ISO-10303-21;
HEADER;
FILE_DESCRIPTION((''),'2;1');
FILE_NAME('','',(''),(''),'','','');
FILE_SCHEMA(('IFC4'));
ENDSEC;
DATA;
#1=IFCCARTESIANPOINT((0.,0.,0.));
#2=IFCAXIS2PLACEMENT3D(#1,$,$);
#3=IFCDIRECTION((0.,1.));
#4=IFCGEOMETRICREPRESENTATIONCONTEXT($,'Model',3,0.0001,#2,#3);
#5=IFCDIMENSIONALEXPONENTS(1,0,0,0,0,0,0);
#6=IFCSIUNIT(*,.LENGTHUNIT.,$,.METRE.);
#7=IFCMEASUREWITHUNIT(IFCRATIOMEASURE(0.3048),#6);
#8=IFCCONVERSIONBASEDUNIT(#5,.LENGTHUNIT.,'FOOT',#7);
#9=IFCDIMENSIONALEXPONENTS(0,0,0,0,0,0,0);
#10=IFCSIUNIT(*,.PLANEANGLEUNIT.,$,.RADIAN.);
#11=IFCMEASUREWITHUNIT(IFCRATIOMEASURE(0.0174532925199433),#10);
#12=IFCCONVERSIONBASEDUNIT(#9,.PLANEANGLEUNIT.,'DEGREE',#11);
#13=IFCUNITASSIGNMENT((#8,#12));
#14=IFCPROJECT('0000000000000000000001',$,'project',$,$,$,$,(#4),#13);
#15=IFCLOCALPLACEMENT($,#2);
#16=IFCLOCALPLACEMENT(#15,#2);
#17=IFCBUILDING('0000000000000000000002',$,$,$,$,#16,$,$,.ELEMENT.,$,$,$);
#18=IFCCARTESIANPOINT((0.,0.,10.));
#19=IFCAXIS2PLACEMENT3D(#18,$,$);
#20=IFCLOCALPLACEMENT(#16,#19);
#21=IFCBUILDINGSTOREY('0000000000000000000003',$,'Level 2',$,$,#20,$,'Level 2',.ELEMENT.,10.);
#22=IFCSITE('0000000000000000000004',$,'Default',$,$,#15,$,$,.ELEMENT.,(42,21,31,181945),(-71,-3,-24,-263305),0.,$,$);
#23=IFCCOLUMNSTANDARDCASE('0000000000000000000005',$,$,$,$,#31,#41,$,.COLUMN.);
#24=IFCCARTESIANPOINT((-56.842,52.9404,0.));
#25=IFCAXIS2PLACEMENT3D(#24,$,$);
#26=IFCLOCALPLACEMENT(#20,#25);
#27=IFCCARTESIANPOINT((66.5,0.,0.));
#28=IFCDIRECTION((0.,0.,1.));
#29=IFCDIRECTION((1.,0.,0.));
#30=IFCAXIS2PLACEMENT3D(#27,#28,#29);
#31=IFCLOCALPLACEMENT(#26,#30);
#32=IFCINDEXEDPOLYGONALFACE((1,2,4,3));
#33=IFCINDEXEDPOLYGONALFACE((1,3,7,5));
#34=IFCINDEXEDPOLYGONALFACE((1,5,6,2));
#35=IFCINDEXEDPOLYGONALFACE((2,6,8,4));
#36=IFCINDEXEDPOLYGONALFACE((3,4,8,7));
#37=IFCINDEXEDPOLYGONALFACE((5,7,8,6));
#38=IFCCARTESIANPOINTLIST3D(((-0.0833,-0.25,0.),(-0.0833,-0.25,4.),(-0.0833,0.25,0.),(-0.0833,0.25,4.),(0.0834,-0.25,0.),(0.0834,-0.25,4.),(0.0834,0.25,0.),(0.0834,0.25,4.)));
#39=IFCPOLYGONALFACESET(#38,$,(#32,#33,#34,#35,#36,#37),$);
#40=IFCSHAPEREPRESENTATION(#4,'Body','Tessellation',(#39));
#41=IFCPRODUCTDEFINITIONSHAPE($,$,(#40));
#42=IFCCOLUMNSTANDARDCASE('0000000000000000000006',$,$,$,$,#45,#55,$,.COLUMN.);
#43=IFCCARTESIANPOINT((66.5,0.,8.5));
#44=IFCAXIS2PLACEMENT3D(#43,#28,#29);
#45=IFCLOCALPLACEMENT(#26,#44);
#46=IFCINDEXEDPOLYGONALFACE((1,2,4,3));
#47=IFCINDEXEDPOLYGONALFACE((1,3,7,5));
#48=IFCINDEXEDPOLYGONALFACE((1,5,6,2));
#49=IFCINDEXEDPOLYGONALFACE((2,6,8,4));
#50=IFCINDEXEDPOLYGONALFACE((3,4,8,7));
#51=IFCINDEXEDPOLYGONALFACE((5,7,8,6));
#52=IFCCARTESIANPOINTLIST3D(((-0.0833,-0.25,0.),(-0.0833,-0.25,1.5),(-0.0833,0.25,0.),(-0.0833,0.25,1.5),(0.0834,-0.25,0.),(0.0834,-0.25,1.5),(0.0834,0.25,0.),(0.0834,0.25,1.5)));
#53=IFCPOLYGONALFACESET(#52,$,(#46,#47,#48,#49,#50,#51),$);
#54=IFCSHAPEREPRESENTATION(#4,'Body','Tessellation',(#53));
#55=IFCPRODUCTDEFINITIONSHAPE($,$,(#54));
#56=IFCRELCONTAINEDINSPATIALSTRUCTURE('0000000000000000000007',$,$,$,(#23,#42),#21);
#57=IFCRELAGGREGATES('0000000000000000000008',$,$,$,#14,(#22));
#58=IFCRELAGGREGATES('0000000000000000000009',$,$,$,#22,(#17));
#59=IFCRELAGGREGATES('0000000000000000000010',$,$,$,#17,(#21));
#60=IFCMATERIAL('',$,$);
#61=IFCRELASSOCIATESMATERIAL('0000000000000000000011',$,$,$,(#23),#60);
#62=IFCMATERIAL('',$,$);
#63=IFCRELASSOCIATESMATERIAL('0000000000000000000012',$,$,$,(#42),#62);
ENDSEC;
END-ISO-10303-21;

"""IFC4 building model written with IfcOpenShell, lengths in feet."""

from ifc_helpers import new_model, entity, si_unit, converted_unit, direction, frame, origin, place, context, project, spatial, rectangle, extrude, material, element, save


model = new_model("IFC4")

# Units and contexts
model_context = context("Model", 3, precision=0.0001, world=origin(), true_north=direction((0.0, 1.0)))
ifc_project = project(units=[converted_unit("LENGTHUNIT", "FOOT", entity("IfcRatioMeasure", 0.3048), si_unit("LENGTHUNIT", "METRE"), dimensions=[1, 0, 0, 0, 0, 0, 0]), converted_unit("PLANEANGLEUNIT", "DEGREE", entity("IfcRatioMeasure", 0.0174532925199433), si_unit("PLANEANGLEUNIT", "RADIAN"), dimensions=[0, 0, 0, 0, 0, 0, 0])], contexts=[model_context])

# Site, building, storey
site_placement = place(None, origin())
site = spatial("IfcSite", under=ifc_project, at=site_placement, Name="Default", CompositionType="ELEMENT", RefLatitude=(42, 21, 31, 181945), RefLongitude=(-71, -3, -24, -263305), RefElevation=0.0)
building_placement = place(site_placement, origin())
building = spatial("IfcBuilding", under=site, at=building_placement, CompositionType="ELEMENT")
storey_placement = place(building_placement, frame((0.0, 0.0, 10.0)))
storey = spatial("IfcBuildingStorey", under=building, at=storey_placement, Name="Level 2", LongName="Level 2", CompositionType="ELEMENT", Elevation=10.0)

# Columns
placement = place(storey_placement, frame((-56.842, 52.9404, 0.0)))
ifc_material_1 = material(Name="")
for number, where, z_axis, x_axis in (
    (1, (66.5, 0.0, 0.0), (0.0, 0.0, 1.0), (1.0, 0.0, 0.0)),
):
    element("IfcColumnStandardCase", number, at=place(placement, frame(where, z_axis=z_axis, x_axis=x_axis)), inside=storey, material=ifc_material_1, PredefinedType="COLUMN", context=model_context, shape_type="SweptSolid", body=[
        extrude(rectangle(XDim=0.1667, YDim=0.5), origin(), (0.0, 0.0, 1.0), 4.0),
    ])
ifc_material_2 = material(Name="")
for number, where, z_axis, x_axis in (
    (2, (66.5, 0.0, 8.5), (0.0, 0.0, 1.0), (1.0, 0.0, 0.0)),
):
    element("IfcColumnStandardCase", number, at=place(placement, frame(where, z_axis=z_axis, x_axis=x_axis)), inside=storey, material=ifc_material_2, PredefinedType="COLUMN", context=model_context, shape_type="SweptSolid", body=[
        extrude(rectangle(XDim=0.1667, YDim=0.5), origin(), (0.0, 0.0, 1.0), 1.5),
    ])

save(model, "model.ifc")
